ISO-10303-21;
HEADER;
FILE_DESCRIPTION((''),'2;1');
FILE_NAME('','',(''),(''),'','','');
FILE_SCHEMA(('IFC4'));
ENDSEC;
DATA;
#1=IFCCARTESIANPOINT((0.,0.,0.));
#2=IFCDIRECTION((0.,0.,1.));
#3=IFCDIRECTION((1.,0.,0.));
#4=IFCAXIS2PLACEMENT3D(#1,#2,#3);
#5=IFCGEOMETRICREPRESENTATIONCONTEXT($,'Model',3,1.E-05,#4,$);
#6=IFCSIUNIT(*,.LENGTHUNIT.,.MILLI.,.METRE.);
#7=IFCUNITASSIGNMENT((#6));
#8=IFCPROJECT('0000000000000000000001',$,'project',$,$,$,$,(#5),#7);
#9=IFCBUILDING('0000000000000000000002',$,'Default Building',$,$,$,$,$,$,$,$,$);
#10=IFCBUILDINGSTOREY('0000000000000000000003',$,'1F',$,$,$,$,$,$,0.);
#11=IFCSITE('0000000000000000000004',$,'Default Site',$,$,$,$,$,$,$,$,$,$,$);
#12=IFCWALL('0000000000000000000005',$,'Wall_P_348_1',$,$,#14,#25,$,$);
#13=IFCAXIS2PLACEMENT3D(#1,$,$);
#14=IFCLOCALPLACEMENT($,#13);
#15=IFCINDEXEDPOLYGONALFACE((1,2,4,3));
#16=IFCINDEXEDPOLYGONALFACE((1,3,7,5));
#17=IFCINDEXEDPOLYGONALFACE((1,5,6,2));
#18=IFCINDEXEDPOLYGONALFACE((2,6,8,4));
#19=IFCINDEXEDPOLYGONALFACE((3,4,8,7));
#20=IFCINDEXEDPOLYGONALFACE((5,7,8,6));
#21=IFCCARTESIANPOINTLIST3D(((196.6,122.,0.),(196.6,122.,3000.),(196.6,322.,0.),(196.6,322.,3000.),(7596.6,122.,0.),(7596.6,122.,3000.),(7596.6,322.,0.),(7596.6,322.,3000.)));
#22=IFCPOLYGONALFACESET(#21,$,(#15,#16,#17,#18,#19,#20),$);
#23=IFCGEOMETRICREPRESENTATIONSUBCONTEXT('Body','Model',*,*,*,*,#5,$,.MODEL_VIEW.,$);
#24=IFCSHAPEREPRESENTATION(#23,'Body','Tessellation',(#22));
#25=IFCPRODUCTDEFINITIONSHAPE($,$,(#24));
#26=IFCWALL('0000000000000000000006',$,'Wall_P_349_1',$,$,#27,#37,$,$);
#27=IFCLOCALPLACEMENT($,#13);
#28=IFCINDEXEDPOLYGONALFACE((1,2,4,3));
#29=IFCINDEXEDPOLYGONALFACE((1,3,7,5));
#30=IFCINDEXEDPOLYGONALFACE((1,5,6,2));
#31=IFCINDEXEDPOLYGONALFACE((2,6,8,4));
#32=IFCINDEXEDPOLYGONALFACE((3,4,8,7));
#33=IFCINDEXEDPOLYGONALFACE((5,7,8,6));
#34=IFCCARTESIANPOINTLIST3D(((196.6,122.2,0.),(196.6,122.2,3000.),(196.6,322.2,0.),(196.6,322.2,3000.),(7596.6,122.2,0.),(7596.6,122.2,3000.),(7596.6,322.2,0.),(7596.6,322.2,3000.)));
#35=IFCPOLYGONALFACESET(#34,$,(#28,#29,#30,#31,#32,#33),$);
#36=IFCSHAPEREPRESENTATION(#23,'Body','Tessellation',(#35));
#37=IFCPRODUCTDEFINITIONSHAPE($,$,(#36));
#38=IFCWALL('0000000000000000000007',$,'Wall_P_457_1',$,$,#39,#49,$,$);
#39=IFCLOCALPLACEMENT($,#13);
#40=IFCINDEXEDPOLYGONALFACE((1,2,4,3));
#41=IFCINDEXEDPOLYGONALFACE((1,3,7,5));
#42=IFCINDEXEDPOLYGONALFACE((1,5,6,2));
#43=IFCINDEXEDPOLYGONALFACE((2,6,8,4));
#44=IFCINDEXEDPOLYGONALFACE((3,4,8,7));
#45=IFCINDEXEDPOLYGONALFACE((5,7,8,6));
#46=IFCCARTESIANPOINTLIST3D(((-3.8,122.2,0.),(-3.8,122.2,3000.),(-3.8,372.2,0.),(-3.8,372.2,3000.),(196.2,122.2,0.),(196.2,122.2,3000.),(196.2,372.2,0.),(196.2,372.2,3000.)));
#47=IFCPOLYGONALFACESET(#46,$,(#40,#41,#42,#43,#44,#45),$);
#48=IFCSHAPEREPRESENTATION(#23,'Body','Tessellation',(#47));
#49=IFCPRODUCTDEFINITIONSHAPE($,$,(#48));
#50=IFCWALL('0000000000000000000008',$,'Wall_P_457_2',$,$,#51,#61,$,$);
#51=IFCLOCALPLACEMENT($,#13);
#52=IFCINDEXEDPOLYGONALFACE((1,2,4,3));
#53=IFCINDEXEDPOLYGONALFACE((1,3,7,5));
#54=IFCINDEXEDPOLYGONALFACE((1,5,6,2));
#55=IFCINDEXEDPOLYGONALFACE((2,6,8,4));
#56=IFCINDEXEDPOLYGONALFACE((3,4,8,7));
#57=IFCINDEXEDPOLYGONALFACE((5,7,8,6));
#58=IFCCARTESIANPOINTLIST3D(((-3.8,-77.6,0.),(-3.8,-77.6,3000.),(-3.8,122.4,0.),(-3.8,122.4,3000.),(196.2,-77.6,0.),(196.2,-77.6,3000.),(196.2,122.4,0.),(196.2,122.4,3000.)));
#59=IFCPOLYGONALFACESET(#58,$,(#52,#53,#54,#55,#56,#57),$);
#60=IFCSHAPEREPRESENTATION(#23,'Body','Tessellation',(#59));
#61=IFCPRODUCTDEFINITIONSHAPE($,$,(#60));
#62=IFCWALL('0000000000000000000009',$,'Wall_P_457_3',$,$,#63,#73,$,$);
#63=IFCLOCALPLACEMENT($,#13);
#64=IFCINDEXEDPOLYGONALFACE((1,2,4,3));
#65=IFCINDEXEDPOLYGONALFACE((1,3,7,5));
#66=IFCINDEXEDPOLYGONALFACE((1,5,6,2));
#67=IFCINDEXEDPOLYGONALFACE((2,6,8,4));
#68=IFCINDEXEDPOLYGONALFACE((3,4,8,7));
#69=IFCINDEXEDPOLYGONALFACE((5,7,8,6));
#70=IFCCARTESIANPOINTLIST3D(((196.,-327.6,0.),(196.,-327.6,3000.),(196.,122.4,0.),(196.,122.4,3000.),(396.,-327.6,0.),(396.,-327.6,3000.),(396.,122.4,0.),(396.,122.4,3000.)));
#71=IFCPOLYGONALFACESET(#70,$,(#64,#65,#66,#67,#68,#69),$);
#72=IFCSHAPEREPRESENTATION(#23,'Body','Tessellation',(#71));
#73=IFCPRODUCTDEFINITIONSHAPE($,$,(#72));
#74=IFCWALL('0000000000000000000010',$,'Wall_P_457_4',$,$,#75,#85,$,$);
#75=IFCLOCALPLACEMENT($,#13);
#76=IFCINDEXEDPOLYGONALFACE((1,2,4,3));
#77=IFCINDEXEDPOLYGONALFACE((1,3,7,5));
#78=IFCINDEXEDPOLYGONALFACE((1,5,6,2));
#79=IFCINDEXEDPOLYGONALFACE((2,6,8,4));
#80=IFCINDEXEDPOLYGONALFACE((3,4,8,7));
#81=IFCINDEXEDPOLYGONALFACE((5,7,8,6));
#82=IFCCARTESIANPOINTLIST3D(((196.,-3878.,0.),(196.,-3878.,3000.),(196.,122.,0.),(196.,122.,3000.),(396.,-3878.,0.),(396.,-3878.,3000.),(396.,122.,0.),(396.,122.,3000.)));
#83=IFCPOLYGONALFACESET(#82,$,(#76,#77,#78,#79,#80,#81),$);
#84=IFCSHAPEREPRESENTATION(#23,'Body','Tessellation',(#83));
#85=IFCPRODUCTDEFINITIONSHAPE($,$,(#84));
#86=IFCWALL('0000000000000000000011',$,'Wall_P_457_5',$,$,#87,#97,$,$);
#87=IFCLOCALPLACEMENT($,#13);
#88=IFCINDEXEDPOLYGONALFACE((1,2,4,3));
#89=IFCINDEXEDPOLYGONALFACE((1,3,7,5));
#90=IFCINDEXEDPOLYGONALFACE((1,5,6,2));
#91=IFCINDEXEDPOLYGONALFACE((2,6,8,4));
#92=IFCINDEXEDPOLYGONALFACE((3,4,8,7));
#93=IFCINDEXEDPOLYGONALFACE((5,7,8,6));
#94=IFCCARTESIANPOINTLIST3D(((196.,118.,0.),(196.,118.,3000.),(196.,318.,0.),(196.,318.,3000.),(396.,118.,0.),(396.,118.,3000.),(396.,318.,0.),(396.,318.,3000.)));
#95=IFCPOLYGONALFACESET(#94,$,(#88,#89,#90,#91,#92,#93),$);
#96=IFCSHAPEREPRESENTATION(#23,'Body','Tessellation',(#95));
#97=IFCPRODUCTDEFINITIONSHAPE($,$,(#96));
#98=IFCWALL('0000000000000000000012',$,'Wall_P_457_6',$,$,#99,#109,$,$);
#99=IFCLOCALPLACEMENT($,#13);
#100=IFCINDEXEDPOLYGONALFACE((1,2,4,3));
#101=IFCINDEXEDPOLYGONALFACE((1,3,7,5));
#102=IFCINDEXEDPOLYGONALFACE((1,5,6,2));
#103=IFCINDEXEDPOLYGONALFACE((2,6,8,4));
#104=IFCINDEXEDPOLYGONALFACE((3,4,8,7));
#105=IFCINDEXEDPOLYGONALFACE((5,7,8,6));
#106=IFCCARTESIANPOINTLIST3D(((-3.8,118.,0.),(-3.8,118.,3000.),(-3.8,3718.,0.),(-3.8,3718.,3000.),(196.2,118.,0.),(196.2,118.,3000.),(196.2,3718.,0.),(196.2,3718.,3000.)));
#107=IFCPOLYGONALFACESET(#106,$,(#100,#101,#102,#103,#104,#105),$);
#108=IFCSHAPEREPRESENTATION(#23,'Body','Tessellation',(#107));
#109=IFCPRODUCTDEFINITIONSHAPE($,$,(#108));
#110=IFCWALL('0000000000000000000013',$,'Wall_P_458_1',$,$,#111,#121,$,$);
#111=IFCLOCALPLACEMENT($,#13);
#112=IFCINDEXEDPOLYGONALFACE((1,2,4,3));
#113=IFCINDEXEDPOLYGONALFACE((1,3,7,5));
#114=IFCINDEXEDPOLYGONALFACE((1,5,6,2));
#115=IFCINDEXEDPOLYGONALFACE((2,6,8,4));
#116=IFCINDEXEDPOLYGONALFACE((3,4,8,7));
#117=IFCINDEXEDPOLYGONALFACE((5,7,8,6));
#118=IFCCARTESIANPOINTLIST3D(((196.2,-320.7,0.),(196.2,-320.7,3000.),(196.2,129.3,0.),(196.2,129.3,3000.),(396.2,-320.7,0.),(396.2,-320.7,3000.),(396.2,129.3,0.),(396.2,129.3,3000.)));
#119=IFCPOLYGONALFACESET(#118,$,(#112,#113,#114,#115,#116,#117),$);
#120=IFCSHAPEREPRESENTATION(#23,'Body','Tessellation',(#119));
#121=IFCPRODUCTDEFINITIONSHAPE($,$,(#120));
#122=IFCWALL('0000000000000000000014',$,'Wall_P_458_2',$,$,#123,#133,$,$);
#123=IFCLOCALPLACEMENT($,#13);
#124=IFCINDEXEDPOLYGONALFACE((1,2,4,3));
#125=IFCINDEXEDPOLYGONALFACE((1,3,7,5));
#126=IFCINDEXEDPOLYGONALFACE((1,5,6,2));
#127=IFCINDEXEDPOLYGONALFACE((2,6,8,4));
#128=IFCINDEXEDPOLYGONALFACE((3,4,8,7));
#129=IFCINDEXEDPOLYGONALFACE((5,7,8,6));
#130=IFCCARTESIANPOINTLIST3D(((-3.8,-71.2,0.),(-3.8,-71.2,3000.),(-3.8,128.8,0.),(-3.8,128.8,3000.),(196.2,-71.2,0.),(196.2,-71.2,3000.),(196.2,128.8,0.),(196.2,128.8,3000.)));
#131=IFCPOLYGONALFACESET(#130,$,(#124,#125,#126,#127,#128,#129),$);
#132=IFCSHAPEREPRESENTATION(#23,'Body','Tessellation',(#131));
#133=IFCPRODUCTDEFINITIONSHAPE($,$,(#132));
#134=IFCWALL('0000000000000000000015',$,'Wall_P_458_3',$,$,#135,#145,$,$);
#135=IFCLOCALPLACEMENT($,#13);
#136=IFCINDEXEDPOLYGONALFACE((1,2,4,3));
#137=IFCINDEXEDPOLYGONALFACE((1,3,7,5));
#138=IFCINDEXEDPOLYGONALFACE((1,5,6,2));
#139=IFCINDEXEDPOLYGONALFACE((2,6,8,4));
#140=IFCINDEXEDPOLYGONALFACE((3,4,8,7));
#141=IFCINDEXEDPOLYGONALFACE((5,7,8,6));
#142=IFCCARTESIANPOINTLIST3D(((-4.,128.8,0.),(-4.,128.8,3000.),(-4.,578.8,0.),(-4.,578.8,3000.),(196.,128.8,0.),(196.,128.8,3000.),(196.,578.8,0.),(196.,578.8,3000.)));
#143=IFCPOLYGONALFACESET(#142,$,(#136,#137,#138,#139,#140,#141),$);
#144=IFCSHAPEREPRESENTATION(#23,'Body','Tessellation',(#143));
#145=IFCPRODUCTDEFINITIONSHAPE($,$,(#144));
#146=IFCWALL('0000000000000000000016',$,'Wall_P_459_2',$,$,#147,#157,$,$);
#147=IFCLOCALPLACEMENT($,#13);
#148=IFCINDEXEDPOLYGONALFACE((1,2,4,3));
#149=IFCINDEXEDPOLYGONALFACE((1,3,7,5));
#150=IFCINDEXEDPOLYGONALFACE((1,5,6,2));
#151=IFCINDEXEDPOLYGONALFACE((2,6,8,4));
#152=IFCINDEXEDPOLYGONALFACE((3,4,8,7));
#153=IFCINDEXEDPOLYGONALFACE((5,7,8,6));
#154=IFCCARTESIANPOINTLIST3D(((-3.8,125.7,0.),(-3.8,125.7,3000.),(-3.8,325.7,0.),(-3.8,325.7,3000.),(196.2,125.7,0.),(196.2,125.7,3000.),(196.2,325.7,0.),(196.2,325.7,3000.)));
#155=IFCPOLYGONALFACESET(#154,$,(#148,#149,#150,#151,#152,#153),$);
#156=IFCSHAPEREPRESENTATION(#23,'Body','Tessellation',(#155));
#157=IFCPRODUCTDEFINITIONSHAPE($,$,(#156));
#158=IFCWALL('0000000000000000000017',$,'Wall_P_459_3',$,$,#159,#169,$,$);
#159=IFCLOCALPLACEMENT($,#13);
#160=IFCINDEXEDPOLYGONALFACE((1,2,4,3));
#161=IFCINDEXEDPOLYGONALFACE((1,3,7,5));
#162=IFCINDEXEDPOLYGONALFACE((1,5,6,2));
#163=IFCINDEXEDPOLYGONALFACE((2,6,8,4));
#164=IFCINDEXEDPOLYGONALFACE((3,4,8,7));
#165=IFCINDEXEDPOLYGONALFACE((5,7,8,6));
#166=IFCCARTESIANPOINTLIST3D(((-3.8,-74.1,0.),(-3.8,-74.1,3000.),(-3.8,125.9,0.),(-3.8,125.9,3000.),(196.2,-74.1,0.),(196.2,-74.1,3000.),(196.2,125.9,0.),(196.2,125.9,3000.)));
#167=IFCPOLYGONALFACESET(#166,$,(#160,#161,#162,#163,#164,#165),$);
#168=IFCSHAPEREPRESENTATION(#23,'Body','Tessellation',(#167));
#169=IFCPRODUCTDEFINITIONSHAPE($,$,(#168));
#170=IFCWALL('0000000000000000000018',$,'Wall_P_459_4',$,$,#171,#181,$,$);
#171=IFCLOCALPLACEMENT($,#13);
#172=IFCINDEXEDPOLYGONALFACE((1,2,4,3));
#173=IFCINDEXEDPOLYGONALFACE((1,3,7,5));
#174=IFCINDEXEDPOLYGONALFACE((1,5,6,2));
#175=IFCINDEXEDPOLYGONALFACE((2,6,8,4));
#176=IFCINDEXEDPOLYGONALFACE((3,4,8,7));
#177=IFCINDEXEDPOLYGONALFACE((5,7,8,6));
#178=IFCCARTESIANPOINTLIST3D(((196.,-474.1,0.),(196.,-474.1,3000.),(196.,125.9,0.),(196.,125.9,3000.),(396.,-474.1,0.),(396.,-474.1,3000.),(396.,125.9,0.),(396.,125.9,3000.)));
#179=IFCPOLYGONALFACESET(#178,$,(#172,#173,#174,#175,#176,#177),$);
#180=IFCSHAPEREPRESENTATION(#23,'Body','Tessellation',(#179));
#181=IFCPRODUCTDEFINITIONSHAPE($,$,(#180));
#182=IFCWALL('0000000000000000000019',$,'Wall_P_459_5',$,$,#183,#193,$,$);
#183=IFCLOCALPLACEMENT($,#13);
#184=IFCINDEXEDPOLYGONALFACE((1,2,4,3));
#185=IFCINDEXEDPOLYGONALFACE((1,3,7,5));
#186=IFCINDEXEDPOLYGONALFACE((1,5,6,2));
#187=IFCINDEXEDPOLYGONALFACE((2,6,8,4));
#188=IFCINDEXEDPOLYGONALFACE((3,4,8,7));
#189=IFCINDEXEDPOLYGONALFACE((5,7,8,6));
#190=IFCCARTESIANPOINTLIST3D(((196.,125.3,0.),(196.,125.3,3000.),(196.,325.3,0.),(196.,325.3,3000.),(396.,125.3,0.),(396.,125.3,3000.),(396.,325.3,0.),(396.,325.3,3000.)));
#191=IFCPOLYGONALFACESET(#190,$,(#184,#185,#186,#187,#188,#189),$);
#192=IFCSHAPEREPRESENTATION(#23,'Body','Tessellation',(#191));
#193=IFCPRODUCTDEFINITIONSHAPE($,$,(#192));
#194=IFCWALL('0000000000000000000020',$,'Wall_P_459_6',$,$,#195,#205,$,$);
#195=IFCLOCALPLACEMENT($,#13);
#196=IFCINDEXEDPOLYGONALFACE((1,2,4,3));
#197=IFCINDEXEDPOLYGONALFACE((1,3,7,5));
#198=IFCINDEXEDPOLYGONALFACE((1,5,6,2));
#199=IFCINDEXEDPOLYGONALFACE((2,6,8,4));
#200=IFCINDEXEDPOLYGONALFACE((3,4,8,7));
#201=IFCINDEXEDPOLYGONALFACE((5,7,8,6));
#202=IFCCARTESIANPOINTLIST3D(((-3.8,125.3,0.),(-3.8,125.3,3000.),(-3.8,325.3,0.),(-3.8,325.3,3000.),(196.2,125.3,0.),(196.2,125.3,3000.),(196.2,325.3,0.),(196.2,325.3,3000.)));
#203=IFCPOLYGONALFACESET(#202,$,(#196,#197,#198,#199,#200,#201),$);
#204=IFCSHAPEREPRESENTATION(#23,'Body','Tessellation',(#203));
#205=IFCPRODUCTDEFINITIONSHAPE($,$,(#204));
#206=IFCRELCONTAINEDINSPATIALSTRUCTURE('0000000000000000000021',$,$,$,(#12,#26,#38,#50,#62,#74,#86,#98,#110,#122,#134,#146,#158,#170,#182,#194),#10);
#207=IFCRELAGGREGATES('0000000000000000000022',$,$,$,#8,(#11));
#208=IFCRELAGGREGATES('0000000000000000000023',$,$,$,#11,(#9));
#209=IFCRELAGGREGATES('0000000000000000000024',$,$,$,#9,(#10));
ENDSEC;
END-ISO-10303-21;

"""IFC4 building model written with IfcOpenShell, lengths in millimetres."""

from ifc_helpers import new_model, si_unit, frame, origin_with_axes, place, context, subcontext, project, spatial, indexed_curve, outline, extrude, element, save


model = new_model("IFC4")

# Units and contexts
model_context = context("Model", 3, precision=1e-05, world=origin_with_axes())
body_context = subcontext(model_context, "Body", "Model", "MODEL_VIEW")
ifc_project = project(units=[si_unit("LENGTHUNIT", "METRE", prefix="MILLI")], contexts=[model_context])

# Site, building, storey
site = spatial("IfcSite", under=ifc_project, Name="Default Site")
building = spatial("IfcBuilding", under=site, Name="Default Building")
storey = spatial("IfcBuildingStorey", under=building, Name="1F", Elevation=0.0)

# Walls
for number, where, z_axis, x_axis, name in (
    (1, (196.6, 122.0, 0.0), (0.0, 0.0, 1.0), (1.0, 0.0, 0.0), "Wall_P_348_1"),
    (2, (196.6, 122.2, 0.0), (0.0, 0.0, 1.0), (1.0, 0.0, 0.0), "Wall_P_349_1"),
):
    element("IfcWall", number, at=place(None, frame(where, z_axis=z_axis, x_axis=x_axis)), inside=storey, Name=name, context=body_context, shape_type="SweptSolid", body=[
        extrude(outline(indexed_curve([(0.0, 0.0), (0.0, 200.0), (7400.0, 200.0), (7400.0, 0.0), (0.0, 0.0)], self_intersect=False)), origin_with_axes(), (0.0, 0.0, 1.0), 3000.0),
    ])
wall_1_placement = place(None, frame((196.2, 122.2, 0.0), z_axis=(0.0, 0.0, 1.0), x_axis=(0.0, 1.0, 0.0)))
element("IfcWall", 3, at=wall_1_placement, inside=storey, Name="Wall_P_457_1", context=body_context, shape_type="SweptSolid", body=[
    extrude(outline(indexed_curve([(0.0, 0.0), (0.0, 200.0), (250.0, 200.0), (250.0, 0.0), (0.0, 0.0)], self_intersect=False)), origin_with_axes(), (0.0, 0.0, 1.0), 3000.0),
])
wall_2_placement = place(None, frame((196.2, 122.4, 0.0), z_axis=(0.0, 0.0, 1.0), x_axis=(-1.0, 0.0, 0.0)))
element("IfcWall", 4, at=wall_2_placement, inside=storey, Name="Wall_P_457_2", context=body_context, shape_type="SweptSolid", body=[
    extrude(outline(indexed_curve([(0.0, 0.0), (0.0, 200.0), (200.0, 200.0), (200.0, 0.0), (0.0, 0.0)], self_intersect=False)), origin_with_axes(), (0.0, 0.0, 1.0), 3000.0),
])
wall_3_placement = place(None, frame((196.0, 122.4, 0.0), z_axis=(0.0, 0.0, 1.0), x_axis=(0.0, -1.0, 0.0)))
element("IfcWall", 5, at=wall_3_placement, inside=storey, Name="Wall_P_457_3", context=body_context, shape_type="SweptSolid", body=[
    extrude(outline(indexed_curve([(0.0, 0.0), (0.0, 200.0), (450.0, 200.0), (450.0, 0.0), (0.0, 0.0)], self_intersect=False)), origin_with_axes(), (0.0, 0.0, 1.0), 3000.0),
])
wall_4_placement = place(None, frame((196.0, 122.0, 0.0), z_axis=(0.0, 0.0, 1.0), x_axis=(0.0, -1.0, 0.0)))
element("IfcWall", 6, at=wall_4_placement, inside=storey, Name="Wall_P_457_4", context=body_context, shape_type="SweptSolid", body=[
    extrude(outline(indexed_curve([(0.0, 0.0), (0.0, 200.0), (4000.0, 200.0), (4000.0, 0.0), (0.0, 0.0)], self_intersect=False)), origin_with_axes(), (0.0, 0.0, 1.0), 3000.0),
])
wall_5_placement = place(None, frame((196.0, 118.0, 0.0), z_axis=(0.0, 0.0, 1.0), x_axis=(1.0, 0.0, 0.0)))
element("IfcWall", 7, at=wall_5_placement, inside=storey, Name="Wall_P_457_5", context=body_context, shape_type="SweptSolid", body=[
    extrude(outline(indexed_curve([(0.0, 0.0), (0.0, 200.0), (200.0, 200.0), (200.0, 0.0), (0.0, 0.0)], self_intersect=False)), origin_with_axes(), (0.0, 0.0, 1.0), 3000.0),
])
wall_6_placement = place(None, frame((196.2, 118.0, 0.0), z_axis=(0.0, 0.0, 1.0), x_axis=(0.0, 1.0, 0.0)))
element("IfcWall", 8, at=wall_6_placement, inside=storey, Name="Wall_P_457_6", context=body_context, shape_type="SweptSolid", body=[
    extrude(outline(indexed_curve([(0.0, 0.0), (0.0, 200.0), (3600.0, 200.0), (3600.0, 0.0), (0.0, 0.0)], self_intersect=False)), origin_with_axes(), (0.0, 0.0, 1.0), 3000.0),
])
wall_7_placement = place(None, frame((196.2, 129.3, 0.0), z_axis=(0.0, 0.0, 1.0), x_axis=(0.0, -1.0, 0.0)))
element("IfcWall", 9, at=wall_7_placement, inside=storey, Name="Wall_P_458_1", context=body_context, shape_type="SweptSolid", body=[
    extrude(outline(indexed_curve([(0.0, 0.0), (0.0, 200.0), (450.0, 200.0), (450.0, 0.0), (0.0, 0.0)], self_intersect=False)), origin_with_axes(), (0.0, 0.0, 1.0), 3000.0),
])
wall_8_placement = place(None, frame((196.2, 128.8, 0.0), z_axis=(0.0, 0.0, 1.0), x_axis=(-1.0, 0.0, 0.0)))
element("IfcWall", 10, at=wall_8_placement, inside=storey, Name="Wall_P_458_2", context=body_context, shape_type="SweptSolid", body=[
    extrude(outline(indexed_curve([(0.0, 0.0), (0.0, 200.0), (200.0, 200.0), (200.0, 0.0), (0.0, 0.0)], self_intersect=False)), origin_with_axes(), (0.0, 0.0, 1.0), 3000.0),
])
wall_9_placement = place(None, frame((196.0, 128.8, 0.0), z_axis=(0.0, 0.0, 1.0), x_axis=(0.0, 1.0, 0.0)))
element("IfcWall", 11, at=wall_9_placement, inside=storey, Name="Wall_P_458_3", context=body_context, shape_type="SweptSolid", body=[
    extrude(outline(indexed_curve([(0.0, 0.0), (0.0, 200.0), (450.0, 200.0), (450.0, 0.0), (0.0, 0.0)], self_intersect=False)), origin_with_axes(), (0.0, 0.0, 1.0), 3000.0),
])
wall_10_placement = place(None, frame((196.2, 125.7, 0.0), z_axis=(0.0, 0.0, 1.0), x_axis=(0.0, 1.0, 0.0)))
element("IfcWall", 12, at=wall_10_placement, inside=storey, Name="Wall_P_459_2", context=body_context, shape_type="SweptSolid", body=[
    extrude(outline(indexed_curve([(0.0, 0.0), (0.0, 200.0), (200.0, 200.0), (200.0, 0.0), (0.0, 0.0)], self_intersect=False)), origin_with_axes(), (0.0, 0.0, 1.0), 3000.0),
])
wall_11_placement = place(None, frame((196.2, 125.9, 0.0), z_axis=(0.0, 0.0, 1.0), x_axis=(-1.0, 0.0, 0.0)))
element("IfcWall", 13, at=wall_11_placement, inside=storey, Name="Wall_P_459_3", context=body_context, shape_type="SweptSolid", body=[
    extrude(outline(indexed_curve([(0.0, 0.0), (0.0, 200.0), (200.0, 200.0), (200.0, 0.0), (0.0, 0.0)], self_intersect=False)), origin_with_axes(), (0.0, 0.0, 1.0), 3000.0),
])
wall_12_placement = place(None, frame((196.0, 125.9, 0.0), z_axis=(0.0, 0.0, 1.0), x_axis=(0.0, -1.0, 0.0)))
element("IfcWall", 14, at=wall_12_placement, inside=storey, Name="Wall_P_459_4", context=body_context, shape_type="SweptSolid", body=[
    extrude(outline(indexed_curve([(0.0, 0.0), (0.0, 200.0), (600.0, 200.0), (600.0, 0.0), (0.0, 0.0)], self_intersect=False)), origin_with_axes(), (0.0, 0.0, 1.0), 3000.0),
])
wall_13_placement = place(None, frame((196.0, 125.3, 0.0), z_axis=(0.0, 0.0, 1.0), x_axis=(1.0, 0.0, 0.0)))
element("IfcWall", 15, at=wall_13_placement, inside=storey, Name="Wall_P_459_5", context=body_context, shape_type="SweptSolid", body=[
    extrude(outline(indexed_curve([(0.0, 0.0), (0.0, 200.0), (200.0, 200.0), (200.0, 0.0), (0.0, 0.0)], self_intersect=False)), origin_with_axes(), (0.0, 0.0, 1.0), 3000.0),
])
wall_14_placement = place(None, frame((196.2, 125.3, 0.0), z_axis=(0.0, 0.0, 1.0), x_axis=(0.0, 1.0, 0.0)))
element("IfcWall", 16, at=wall_14_placement, inside=storey, Name="Wall_P_459_6", context=body_context, shape_type="SweptSolid", body=[
    extrude(outline(indexed_curve([(0.0, 0.0), (0.0, 200.0), (200.0, 200.0), (200.0, 0.0), (0.0, 0.0)], self_intersect=False)), origin_with_axes(), (0.0, 0.0, 1.0), 3000.0),
])

save(model, "model.ifc")
